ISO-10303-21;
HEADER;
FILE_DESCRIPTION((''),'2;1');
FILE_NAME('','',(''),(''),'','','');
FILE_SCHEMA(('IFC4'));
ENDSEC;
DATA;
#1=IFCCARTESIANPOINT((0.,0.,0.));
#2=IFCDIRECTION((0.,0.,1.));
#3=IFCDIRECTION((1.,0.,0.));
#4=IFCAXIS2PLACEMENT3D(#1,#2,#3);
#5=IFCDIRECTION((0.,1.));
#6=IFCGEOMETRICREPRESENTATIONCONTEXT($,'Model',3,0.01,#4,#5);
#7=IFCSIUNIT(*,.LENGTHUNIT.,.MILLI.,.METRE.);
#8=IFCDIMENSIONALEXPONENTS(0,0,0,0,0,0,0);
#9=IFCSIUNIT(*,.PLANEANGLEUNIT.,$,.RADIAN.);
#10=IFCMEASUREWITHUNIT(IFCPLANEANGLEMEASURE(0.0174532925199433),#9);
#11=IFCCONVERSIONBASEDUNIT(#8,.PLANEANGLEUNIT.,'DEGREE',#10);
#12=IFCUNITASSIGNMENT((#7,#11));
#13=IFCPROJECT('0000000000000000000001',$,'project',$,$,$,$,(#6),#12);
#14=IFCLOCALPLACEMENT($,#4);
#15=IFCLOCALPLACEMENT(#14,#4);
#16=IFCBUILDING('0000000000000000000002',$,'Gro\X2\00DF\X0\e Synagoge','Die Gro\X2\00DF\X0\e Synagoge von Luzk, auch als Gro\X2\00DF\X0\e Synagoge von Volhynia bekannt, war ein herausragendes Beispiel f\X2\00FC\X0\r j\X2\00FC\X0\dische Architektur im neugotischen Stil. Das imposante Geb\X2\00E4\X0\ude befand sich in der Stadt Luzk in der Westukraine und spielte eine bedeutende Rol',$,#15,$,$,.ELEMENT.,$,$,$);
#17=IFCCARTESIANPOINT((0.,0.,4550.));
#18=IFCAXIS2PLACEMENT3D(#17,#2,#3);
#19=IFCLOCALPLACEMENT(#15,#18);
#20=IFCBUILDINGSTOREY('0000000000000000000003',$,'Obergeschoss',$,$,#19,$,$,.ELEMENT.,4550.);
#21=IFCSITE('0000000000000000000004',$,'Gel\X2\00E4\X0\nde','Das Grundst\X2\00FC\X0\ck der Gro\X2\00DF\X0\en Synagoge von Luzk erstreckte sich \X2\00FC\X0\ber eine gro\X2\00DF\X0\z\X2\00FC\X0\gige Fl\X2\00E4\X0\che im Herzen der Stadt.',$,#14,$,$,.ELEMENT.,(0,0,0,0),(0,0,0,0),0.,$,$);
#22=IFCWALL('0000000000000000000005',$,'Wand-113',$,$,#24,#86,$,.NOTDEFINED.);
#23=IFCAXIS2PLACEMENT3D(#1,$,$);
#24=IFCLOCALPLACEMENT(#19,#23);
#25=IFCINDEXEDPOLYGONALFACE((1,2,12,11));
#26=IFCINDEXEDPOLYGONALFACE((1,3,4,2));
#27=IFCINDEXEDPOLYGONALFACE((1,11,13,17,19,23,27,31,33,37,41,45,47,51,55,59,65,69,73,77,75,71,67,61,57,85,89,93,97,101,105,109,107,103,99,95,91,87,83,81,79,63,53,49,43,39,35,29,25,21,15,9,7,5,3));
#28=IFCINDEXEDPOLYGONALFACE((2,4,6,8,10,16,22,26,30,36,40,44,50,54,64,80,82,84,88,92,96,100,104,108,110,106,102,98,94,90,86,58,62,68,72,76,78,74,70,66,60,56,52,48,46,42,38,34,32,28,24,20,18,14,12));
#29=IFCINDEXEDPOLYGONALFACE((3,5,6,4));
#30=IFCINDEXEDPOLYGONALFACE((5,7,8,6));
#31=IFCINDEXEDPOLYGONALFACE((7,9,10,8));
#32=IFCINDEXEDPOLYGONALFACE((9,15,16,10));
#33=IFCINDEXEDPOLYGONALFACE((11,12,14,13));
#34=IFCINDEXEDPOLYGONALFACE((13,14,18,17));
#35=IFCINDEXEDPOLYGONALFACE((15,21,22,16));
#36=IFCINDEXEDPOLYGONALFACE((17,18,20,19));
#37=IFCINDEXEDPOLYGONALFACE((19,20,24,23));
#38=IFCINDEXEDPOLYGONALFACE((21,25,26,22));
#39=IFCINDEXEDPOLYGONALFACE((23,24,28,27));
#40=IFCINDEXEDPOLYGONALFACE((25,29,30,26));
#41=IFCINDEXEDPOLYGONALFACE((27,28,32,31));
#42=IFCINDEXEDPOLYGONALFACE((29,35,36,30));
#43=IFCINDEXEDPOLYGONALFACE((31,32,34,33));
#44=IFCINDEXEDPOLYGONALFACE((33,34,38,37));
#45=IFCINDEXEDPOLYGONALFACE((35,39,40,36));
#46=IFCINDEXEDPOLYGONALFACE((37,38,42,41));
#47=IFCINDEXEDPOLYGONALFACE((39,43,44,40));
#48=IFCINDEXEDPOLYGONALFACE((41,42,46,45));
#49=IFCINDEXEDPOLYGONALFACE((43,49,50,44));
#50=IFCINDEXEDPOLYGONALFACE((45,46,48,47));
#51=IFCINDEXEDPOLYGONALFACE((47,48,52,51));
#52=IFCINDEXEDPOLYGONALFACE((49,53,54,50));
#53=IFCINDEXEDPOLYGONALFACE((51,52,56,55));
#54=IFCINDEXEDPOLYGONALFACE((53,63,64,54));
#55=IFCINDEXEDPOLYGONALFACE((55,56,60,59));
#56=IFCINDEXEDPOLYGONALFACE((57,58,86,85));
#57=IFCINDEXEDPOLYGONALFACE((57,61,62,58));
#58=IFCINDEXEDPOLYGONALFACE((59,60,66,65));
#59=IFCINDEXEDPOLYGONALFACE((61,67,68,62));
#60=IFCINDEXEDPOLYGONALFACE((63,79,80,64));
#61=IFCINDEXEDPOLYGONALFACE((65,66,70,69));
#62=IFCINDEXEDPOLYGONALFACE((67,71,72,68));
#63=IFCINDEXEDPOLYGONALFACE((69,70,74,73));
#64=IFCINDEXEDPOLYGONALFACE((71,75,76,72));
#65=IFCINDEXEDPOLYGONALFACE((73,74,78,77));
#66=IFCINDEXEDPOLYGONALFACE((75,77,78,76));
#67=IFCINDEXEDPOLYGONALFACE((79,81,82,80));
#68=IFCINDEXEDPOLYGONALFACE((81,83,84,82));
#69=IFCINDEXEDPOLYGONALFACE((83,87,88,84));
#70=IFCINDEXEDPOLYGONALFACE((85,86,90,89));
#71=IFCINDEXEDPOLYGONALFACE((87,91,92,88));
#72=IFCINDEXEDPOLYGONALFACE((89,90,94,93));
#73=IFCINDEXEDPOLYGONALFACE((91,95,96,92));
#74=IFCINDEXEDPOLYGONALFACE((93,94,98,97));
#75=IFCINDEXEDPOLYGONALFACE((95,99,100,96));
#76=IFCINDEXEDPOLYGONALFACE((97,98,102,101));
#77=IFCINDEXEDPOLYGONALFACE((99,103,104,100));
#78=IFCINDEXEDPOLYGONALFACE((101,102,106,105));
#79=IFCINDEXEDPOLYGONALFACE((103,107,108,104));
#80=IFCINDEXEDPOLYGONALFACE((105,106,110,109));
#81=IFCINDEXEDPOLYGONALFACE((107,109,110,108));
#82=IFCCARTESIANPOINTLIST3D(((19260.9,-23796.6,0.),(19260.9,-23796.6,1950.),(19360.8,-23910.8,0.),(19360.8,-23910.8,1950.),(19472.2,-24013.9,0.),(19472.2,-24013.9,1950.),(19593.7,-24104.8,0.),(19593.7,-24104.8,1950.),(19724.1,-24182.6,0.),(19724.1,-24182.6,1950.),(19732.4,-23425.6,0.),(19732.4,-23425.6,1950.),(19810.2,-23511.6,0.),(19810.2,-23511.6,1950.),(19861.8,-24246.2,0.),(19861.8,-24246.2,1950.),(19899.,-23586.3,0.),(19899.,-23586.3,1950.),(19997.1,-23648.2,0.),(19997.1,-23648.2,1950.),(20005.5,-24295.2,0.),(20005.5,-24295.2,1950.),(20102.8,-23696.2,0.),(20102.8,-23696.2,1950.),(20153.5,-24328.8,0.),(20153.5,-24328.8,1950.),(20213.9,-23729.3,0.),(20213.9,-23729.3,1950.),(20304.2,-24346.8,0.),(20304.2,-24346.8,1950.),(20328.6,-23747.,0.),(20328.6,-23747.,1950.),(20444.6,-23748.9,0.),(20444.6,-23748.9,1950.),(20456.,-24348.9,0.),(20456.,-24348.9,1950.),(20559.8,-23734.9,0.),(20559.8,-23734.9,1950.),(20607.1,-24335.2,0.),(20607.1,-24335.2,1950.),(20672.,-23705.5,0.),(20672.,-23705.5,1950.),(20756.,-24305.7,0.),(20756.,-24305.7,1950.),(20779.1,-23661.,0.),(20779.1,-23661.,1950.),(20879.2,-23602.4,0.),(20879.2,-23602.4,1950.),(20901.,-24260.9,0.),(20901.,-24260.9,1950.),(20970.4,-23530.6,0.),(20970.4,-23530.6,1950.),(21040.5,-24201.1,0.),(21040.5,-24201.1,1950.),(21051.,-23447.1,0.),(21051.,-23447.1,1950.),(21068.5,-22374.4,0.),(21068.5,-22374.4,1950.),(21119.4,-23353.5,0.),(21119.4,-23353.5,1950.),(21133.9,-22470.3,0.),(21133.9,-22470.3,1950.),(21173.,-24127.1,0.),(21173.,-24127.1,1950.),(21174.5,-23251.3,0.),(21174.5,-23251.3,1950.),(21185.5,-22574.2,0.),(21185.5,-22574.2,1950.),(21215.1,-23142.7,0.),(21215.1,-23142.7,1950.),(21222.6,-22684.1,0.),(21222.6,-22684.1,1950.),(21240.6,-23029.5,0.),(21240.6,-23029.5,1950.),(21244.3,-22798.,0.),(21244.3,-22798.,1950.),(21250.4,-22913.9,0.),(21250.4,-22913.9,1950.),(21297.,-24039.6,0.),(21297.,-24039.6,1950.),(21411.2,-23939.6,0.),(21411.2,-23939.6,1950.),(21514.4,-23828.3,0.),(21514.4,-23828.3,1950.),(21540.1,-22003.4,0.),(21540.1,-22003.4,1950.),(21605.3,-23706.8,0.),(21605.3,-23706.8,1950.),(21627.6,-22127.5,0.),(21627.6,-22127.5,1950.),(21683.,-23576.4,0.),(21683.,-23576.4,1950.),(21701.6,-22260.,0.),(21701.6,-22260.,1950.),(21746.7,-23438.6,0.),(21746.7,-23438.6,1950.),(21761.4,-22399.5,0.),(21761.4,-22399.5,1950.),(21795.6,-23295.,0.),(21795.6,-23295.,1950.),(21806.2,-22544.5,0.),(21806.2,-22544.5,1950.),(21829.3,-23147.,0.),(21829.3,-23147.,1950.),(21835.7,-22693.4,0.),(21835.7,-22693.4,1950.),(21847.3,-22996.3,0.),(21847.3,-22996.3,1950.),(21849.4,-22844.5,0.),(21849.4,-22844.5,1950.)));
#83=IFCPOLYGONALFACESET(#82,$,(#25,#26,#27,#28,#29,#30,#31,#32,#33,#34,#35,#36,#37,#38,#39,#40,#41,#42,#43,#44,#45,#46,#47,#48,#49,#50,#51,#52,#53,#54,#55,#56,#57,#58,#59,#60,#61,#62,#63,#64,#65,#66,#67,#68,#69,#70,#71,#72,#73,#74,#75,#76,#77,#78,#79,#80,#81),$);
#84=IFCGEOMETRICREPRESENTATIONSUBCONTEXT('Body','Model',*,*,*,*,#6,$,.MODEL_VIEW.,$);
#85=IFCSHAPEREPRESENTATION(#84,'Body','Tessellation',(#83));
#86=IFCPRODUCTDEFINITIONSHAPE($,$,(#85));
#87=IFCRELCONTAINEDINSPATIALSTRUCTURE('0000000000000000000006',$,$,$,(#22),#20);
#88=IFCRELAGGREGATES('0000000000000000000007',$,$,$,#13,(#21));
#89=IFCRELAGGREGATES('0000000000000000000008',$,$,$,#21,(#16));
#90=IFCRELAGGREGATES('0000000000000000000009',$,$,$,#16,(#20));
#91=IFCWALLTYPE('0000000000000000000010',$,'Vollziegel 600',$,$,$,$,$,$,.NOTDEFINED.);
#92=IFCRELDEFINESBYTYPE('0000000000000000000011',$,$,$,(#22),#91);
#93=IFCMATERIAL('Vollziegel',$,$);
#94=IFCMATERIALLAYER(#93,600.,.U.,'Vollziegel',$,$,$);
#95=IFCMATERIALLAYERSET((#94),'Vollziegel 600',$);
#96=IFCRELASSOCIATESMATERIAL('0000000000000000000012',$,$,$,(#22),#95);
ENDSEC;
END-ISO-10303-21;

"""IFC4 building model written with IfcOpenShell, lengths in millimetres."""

from ifc_helpers import new_model, entity, si_unit, converted_unit, direction, frame, origin_with_axes, place, context, subcontext, project, spatial, line, arc, indexed_curve, outline, extrude, material, layer, layer_set, layer_usage, type_object, element, save


model = new_model("IFC4")

# Units and contexts
model_context = context("Model", 3, precision=0.01, world=origin_with_axes(), true_north=direction((0.0, 1.0)))
body_context = subcontext(model_context, "Body", "Model", "MODEL_VIEW")
ifc_project = project(units=[si_unit("LENGTHUNIT", "METRE", prefix="MILLI"), converted_unit("PLANEANGLEUNIT", "DEGREE", entity("IfcPlaneAngleMeasure", 0.0174532925199433), si_unit("PLANEANGLEUNIT", "RADIAN"), dimensions=[0, 0, 0, 0, 0, 0, 0])], contexts=[model_context])

# Site, building, storey
site_placement = place(None, origin_with_axes())
site = spatial("IfcSite", under=ifc_project, at=site_placement, Name="Gelände", Description="Das Grundstück der Großen Synagoge von Luzk erstreckte sich über eine großzügige Fläche im Herzen der Stadt.", CompositionType="ELEMENT", RefLatitude=(0, 0, 0, 0), RefLongitude=(0, 0, 0, 0), RefElevation=0.0)
building_placement = place(site_placement, origin_with_axes())
building = spatial("IfcBuilding", under=site, at=building_placement, Name="Große Synagoge", Description="Die Große Synagoge von Luzk, auch als Große Synagoge von Volhynia bekannt, war ein herausragendes Beispiel für jüdische Architektur im neugotischen Stil. Das imposante Gebäude befand sich in der Stadt Luzk in der Westukraine und spielte eine bedeutende Rol", CompositionType="ELEMENT")
storey_placement = place(building_placement, frame((0.0, 0.0, 4550.0), z_axis=(0.0, 0.0, 1.0), x_axis=(1.0, 0.0, 0.0)))
storey = spatial("IfcBuildingStorey", under=building, at=storey_placement, Name="Obergeschoss", CompositionType="ELEMENT", Elevation=4550.0)

# Shared definitions
ifc_material_1 = material(Name="Vollziegel")

# Wall
ifc_layer_1 = layer(ifc_material_1, 600.0, ventilated="UNKNOWN", Name="Vollziegel")
ifc_layer_set_1 = layer_set([ifc_layer_1], Name="Vollziegel 600")
wall_type_1 = type_object("IfcWallType", Name="Vollziegel 600", PredefinedType="NOTDEFINED")
ifc_layer_usage_1 = layer_usage(ifc_layer_set_1, "AXIS2", "POSITIVE", -600.0)
wall_1_placement = place(storey_placement, frame((19732.4, -23425.6, 0.0), z_axis=(0.0, 0.0, 1.0), x_axis=(0.618314, -0.785931, 0.0)))
element("IfcWall", 1, at=wall_1_placement, inside=storey, type_object=wall_type_1, material=ifc_layer_usage_1, Name="Wand-113", PredefinedType="NOTDEFINED", context=body_context, shape_type="SweptSolid", body=[
    extrude(outline(indexed_curve([(0.0, -600.0), (1450.0, 850.0), (0.0, 2300.0), (0.0, 1700.0), (850.0, 850.0), (0.0, 0.0)], segments=[arc(1, 2, 3), line(3, 4), arc(4, 5, 6), line(6, 1)])), origin_with_axes(), (0.0, 0.0, 1.0), 1950.0),
])

save(model, "model.ifc")
